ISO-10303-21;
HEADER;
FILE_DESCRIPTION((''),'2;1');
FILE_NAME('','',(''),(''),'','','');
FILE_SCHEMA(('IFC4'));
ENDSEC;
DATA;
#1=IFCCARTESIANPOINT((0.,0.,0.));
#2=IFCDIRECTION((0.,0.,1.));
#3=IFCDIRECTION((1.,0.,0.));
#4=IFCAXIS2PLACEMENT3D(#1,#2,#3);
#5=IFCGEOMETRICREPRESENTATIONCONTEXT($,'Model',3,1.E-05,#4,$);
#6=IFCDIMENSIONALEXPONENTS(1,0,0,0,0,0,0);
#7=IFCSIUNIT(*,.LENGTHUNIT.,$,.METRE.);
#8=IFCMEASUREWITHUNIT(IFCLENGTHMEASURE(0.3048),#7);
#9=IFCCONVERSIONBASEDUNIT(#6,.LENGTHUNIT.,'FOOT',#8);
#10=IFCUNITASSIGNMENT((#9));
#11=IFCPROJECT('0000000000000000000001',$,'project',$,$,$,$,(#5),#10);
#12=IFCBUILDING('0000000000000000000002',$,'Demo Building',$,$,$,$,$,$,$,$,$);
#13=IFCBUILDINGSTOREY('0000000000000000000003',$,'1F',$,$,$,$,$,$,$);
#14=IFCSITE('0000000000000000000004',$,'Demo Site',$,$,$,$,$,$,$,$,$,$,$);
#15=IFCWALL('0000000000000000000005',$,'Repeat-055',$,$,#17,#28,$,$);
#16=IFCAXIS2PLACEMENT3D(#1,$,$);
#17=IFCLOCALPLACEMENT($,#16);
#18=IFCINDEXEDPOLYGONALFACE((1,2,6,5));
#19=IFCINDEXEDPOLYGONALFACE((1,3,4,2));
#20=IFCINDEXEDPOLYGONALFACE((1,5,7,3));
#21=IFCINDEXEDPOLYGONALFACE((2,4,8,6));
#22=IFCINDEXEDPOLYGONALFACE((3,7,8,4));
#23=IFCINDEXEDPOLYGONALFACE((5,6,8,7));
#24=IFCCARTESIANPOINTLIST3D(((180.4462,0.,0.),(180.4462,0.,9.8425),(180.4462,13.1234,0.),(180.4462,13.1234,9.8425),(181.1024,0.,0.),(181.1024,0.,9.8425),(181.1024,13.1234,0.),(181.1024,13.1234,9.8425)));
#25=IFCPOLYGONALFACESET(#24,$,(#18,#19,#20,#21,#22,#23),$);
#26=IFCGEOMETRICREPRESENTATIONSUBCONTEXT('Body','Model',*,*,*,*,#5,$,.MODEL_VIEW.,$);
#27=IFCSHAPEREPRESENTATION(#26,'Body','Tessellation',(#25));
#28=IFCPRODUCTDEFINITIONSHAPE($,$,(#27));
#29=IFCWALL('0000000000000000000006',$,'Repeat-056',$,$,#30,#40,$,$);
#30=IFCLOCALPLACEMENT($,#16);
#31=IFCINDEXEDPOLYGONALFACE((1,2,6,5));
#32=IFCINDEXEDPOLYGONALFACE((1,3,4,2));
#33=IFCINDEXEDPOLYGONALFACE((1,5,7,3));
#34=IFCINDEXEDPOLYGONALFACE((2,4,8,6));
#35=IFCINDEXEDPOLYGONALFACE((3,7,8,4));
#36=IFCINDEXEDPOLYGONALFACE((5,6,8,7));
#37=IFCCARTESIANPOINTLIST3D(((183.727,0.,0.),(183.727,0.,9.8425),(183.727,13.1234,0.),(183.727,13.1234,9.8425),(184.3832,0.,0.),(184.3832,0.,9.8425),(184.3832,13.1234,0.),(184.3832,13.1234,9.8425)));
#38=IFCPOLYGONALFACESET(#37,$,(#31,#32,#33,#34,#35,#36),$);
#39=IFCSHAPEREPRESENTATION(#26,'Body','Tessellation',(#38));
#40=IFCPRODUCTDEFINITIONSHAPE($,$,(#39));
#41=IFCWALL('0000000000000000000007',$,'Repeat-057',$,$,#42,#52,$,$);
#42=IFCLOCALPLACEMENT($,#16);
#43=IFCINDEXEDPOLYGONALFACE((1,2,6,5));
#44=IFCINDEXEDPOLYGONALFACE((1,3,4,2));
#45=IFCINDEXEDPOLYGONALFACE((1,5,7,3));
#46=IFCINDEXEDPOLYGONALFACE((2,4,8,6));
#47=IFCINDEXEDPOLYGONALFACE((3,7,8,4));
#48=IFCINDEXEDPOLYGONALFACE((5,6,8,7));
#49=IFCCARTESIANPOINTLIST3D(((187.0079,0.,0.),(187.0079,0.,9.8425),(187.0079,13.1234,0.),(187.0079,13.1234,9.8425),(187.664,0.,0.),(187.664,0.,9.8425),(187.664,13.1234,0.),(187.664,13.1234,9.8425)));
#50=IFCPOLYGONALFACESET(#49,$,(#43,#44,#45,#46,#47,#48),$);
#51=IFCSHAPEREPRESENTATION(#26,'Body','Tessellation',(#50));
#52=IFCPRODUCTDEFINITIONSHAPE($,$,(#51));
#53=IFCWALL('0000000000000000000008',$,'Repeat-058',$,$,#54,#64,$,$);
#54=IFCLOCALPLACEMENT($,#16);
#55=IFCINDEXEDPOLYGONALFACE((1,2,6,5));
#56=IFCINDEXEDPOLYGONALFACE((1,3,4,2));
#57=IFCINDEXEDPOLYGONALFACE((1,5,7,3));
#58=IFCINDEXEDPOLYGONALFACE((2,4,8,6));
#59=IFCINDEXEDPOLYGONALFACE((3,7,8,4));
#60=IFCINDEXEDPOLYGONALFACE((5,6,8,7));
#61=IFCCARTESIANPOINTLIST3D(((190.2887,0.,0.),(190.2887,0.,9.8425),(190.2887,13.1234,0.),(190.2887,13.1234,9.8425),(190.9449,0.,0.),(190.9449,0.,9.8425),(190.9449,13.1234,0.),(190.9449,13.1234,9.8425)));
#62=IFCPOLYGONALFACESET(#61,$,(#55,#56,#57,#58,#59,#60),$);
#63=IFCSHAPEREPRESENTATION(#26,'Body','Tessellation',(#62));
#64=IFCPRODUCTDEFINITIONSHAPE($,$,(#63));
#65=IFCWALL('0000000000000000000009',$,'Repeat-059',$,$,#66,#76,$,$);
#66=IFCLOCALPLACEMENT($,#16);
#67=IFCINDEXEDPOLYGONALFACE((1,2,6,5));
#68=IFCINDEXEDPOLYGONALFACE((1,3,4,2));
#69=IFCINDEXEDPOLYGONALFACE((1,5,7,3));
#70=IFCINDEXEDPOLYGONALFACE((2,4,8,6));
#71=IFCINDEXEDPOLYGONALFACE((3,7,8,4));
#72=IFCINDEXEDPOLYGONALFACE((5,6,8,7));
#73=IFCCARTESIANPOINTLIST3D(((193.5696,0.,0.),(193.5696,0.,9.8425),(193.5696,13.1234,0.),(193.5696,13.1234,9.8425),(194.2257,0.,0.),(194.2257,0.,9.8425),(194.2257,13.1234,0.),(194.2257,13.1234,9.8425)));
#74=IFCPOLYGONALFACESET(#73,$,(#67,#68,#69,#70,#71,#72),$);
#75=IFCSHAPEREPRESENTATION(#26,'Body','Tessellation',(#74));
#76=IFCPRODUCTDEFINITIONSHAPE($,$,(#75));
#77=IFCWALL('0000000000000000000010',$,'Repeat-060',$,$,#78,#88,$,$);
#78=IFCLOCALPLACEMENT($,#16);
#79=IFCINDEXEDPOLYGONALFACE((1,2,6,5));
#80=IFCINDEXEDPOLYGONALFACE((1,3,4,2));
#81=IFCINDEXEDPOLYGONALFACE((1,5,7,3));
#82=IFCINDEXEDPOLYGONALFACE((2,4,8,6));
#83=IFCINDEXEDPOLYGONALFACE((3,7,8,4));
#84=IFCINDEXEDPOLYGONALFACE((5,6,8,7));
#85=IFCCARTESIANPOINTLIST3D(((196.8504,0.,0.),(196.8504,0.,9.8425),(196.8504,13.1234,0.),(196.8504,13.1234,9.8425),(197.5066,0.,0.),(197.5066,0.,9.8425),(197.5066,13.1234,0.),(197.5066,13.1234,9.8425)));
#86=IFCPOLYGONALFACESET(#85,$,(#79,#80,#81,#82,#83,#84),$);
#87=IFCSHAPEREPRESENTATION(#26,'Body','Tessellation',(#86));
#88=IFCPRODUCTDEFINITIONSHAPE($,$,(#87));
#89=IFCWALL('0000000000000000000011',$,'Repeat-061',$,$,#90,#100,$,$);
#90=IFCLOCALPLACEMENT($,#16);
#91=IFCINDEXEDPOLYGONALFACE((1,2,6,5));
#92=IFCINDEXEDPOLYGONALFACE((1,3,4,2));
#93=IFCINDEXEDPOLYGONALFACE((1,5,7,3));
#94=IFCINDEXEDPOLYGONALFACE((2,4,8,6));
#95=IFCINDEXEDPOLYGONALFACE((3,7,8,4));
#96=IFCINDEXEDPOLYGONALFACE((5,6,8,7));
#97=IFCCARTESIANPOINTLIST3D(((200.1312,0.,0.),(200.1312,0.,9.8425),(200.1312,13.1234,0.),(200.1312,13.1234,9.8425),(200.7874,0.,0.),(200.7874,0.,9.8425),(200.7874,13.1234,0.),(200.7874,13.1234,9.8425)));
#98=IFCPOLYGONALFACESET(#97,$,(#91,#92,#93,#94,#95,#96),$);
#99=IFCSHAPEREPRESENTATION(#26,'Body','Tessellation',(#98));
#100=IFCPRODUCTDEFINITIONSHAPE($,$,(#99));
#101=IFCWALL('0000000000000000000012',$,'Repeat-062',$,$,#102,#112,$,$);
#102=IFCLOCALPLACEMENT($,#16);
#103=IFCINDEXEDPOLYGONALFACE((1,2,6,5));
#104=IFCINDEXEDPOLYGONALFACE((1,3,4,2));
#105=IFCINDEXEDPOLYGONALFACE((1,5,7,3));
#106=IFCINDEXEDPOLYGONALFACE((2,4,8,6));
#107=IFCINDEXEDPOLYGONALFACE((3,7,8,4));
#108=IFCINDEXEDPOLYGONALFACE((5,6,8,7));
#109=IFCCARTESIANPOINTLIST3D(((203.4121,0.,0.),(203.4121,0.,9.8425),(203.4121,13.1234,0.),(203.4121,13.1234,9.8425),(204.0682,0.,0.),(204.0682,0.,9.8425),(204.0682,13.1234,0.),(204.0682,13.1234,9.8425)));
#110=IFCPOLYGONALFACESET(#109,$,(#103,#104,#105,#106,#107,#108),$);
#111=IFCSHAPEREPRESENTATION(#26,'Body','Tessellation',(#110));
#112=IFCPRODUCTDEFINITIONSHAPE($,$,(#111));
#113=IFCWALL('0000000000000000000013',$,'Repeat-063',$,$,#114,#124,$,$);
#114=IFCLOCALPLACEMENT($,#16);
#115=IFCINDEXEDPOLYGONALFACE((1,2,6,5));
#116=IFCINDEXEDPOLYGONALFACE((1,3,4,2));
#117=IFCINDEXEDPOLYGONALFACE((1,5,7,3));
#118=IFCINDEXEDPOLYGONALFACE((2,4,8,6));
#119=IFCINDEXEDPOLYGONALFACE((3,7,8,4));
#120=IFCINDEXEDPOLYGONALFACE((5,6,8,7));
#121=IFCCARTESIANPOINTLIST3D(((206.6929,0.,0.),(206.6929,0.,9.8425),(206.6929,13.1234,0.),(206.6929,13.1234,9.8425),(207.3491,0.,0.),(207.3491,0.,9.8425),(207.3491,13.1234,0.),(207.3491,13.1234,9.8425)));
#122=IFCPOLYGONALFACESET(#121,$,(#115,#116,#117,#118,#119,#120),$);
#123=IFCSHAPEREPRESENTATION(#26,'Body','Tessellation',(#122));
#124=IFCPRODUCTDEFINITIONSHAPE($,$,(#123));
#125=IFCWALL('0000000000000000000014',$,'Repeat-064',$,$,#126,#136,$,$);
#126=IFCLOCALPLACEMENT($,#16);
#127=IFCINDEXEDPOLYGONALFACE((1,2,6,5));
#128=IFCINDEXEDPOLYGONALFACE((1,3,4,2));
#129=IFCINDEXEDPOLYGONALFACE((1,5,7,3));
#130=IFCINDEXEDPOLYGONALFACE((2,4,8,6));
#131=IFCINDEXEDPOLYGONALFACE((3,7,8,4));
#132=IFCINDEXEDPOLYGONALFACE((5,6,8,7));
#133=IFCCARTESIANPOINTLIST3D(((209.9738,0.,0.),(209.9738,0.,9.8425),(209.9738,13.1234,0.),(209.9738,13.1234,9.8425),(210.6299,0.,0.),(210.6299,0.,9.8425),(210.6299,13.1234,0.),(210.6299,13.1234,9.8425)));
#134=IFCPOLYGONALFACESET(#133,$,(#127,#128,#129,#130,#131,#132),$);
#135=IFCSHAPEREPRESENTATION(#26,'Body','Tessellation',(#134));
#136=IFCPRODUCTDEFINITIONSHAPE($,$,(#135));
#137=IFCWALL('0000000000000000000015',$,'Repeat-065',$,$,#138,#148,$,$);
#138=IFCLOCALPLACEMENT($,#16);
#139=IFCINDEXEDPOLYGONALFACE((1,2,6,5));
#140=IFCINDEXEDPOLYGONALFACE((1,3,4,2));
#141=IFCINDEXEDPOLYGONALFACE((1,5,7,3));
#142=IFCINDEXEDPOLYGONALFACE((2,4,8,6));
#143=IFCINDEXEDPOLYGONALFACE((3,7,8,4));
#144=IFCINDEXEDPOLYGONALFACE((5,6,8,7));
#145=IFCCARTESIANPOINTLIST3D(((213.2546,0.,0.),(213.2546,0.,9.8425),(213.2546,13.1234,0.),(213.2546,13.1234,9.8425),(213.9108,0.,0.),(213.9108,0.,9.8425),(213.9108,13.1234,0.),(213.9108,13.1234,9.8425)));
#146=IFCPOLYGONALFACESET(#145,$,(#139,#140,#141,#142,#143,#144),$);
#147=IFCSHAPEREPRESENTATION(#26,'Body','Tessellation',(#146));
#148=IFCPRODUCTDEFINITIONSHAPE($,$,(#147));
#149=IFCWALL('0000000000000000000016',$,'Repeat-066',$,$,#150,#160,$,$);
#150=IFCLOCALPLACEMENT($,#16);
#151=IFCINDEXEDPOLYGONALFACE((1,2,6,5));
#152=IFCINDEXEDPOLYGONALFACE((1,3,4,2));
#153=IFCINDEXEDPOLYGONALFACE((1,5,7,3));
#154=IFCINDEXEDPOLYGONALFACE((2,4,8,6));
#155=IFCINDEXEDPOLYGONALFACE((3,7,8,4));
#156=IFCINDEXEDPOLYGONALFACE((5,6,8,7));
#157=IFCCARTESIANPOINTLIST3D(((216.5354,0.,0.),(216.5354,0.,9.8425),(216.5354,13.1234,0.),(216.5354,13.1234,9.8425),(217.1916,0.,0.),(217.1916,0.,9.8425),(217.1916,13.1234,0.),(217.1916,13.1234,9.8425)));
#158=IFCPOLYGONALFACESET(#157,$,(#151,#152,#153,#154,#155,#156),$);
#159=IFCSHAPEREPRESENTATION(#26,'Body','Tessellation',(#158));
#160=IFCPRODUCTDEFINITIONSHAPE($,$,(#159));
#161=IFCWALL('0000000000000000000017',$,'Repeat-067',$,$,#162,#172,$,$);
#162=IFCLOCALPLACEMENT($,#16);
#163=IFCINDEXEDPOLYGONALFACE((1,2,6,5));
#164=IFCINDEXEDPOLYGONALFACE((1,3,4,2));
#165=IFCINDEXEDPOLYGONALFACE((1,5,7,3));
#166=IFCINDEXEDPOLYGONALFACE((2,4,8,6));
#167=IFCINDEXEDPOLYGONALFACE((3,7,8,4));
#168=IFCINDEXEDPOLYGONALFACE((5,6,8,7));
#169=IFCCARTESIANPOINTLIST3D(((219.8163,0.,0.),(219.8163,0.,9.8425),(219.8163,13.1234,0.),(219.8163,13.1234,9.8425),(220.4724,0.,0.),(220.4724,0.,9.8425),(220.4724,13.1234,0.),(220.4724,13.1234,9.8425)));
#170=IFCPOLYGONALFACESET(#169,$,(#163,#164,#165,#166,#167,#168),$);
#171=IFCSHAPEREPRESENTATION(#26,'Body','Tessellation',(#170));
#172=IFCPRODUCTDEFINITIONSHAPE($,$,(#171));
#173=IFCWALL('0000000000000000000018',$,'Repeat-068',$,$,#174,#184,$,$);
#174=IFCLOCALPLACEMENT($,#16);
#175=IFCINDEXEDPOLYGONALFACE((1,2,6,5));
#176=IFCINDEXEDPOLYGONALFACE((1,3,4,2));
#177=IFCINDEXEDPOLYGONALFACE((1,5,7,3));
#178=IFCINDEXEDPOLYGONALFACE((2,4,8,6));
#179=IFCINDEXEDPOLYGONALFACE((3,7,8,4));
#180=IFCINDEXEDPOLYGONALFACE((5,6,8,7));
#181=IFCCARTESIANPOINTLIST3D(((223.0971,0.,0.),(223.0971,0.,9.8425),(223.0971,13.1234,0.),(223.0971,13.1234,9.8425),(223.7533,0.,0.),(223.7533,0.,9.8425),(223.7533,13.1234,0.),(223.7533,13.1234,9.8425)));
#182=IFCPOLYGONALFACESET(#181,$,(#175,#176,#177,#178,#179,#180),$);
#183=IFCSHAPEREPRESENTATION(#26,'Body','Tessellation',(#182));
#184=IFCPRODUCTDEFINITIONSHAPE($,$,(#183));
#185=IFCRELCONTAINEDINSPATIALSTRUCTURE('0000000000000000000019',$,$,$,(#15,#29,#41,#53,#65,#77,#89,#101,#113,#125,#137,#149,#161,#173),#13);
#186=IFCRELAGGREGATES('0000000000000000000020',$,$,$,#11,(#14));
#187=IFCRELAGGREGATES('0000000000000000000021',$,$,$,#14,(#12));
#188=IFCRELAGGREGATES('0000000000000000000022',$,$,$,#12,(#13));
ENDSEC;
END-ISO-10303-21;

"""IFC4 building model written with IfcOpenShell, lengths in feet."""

from ifc_helpers import new_model, entity, si_unit, converted_unit, frame, origin_with_axes, place, context, subcontext, project, spatial, element, save


model = new_model("IFC4")

# Units and contexts
model_context = context("Model", 3, precision=1e-05, world=origin_with_axes())
body_context = subcontext(model_context, "Body", "Model", "MODEL_VIEW")
ifc_project = project(units=[converted_unit("LENGTHUNIT", "FOOT", entity("IfcLengthMeasure", 0.3048), si_unit("LENGTHUNIT", "METRE"), dimensions=[1, 0, 0, 0, 0, 0, 0])], contexts=[model_context])

# Site, building, storey
site = spatial("IfcSite", under=ifc_project, Name="Demo Site")
building = spatial("IfcBuilding", under=site, Name="Demo Building")
storey = spatial("IfcBuildingStorey", under=building, Name="1F")

# Walls
for number, where, z_axis, x_axis, name in (
    (1, (180.4462, 0.0, 0.0), (0.0, 0.0, 1.0), (1.0, 0.0, 0.0), "Repeat-055"),
    (2, (183.727, 0.0, 0.0), (0.0, 0.0, 1.0), (1.0, 0.0, 0.0), "Repeat-056"),
    (3, (187.0079, 0.0, 0.0), (0.0, 0.0, 1.0), (1.0, 0.0, 0.0), "Repeat-057"),
    (4, (190.2887, 0.0, 0.0), (0.0, 0.0, 1.0), (1.0, 0.0, 0.0), "Repeat-058"),
    (5, (193.5696, 0.0, 0.0), (0.0, 0.0, 1.0), (1.0, 0.0, 0.0), "Repeat-059"),
    (6, (196.8504, 0.0, 0.0), (0.0, 0.0, 1.0), (1.0, 0.0, 0.0), "Repeat-060"),
    (7, (200.1312, 0.0, 0.0), (0.0, 0.0, 1.0), (1.0, 0.0, 0.0), "Repeat-061"),
    (8, (203.4121, 0.0, 0.0), (0.0, 0.0, 1.0), (1.0, 0.0, 0.0), "Repeat-062"),
    (9, (206.6929, 0.0, 0.0), (0.0, 0.0, 1.0), (1.0, 0.0, 0.0), "Repeat-063"),
    (10, (209.9738, 0.0, 0.0), (0.0, 0.0, 1.0), (1.0, 0.0, 0.0), "Repeat-064"),
    (11, (213.2546, 0.0, 0.0), (0.0, 0.0, 1.0), (1.0, 0.0, 0.0), "Repeat-065"),
    (12, (216.5354, 0.0, 0.0), (0.0, 0.0, 1.0), (1.0, 0.0, 0.0), "Repeat-066"),
    (13, (219.8163, 0.0, 0.0), (0.0, 0.0, 1.0), (1.0, 0.0, 0.0), "Repeat-067"),
    (14, (223.0971, 0.0, 0.0), (0.0, 0.0, 1.0), (1.0, 0.0, 0.0), "Repeat-068"),
):
    element("IfcWall", number, at=place(None, frame(where, z_axis=z_axis, x_axis=x_axis)), inside=storey, Name=name, context=body_context, shape_type="CSG", body=[
        entity("IfcBlock", entity("IfcAxis2Placement3D", entity("IfcCartesianPoint", [0.0, 0.0, 0.0]), entity("IfcDirection", [0.0, 0.0, 1.0]), entity("IfcDirection", [1.0, 0.0, 0.0])), 0.6562, 13.1234, 9.8425),
    ])

save(model, "model.ifc")
